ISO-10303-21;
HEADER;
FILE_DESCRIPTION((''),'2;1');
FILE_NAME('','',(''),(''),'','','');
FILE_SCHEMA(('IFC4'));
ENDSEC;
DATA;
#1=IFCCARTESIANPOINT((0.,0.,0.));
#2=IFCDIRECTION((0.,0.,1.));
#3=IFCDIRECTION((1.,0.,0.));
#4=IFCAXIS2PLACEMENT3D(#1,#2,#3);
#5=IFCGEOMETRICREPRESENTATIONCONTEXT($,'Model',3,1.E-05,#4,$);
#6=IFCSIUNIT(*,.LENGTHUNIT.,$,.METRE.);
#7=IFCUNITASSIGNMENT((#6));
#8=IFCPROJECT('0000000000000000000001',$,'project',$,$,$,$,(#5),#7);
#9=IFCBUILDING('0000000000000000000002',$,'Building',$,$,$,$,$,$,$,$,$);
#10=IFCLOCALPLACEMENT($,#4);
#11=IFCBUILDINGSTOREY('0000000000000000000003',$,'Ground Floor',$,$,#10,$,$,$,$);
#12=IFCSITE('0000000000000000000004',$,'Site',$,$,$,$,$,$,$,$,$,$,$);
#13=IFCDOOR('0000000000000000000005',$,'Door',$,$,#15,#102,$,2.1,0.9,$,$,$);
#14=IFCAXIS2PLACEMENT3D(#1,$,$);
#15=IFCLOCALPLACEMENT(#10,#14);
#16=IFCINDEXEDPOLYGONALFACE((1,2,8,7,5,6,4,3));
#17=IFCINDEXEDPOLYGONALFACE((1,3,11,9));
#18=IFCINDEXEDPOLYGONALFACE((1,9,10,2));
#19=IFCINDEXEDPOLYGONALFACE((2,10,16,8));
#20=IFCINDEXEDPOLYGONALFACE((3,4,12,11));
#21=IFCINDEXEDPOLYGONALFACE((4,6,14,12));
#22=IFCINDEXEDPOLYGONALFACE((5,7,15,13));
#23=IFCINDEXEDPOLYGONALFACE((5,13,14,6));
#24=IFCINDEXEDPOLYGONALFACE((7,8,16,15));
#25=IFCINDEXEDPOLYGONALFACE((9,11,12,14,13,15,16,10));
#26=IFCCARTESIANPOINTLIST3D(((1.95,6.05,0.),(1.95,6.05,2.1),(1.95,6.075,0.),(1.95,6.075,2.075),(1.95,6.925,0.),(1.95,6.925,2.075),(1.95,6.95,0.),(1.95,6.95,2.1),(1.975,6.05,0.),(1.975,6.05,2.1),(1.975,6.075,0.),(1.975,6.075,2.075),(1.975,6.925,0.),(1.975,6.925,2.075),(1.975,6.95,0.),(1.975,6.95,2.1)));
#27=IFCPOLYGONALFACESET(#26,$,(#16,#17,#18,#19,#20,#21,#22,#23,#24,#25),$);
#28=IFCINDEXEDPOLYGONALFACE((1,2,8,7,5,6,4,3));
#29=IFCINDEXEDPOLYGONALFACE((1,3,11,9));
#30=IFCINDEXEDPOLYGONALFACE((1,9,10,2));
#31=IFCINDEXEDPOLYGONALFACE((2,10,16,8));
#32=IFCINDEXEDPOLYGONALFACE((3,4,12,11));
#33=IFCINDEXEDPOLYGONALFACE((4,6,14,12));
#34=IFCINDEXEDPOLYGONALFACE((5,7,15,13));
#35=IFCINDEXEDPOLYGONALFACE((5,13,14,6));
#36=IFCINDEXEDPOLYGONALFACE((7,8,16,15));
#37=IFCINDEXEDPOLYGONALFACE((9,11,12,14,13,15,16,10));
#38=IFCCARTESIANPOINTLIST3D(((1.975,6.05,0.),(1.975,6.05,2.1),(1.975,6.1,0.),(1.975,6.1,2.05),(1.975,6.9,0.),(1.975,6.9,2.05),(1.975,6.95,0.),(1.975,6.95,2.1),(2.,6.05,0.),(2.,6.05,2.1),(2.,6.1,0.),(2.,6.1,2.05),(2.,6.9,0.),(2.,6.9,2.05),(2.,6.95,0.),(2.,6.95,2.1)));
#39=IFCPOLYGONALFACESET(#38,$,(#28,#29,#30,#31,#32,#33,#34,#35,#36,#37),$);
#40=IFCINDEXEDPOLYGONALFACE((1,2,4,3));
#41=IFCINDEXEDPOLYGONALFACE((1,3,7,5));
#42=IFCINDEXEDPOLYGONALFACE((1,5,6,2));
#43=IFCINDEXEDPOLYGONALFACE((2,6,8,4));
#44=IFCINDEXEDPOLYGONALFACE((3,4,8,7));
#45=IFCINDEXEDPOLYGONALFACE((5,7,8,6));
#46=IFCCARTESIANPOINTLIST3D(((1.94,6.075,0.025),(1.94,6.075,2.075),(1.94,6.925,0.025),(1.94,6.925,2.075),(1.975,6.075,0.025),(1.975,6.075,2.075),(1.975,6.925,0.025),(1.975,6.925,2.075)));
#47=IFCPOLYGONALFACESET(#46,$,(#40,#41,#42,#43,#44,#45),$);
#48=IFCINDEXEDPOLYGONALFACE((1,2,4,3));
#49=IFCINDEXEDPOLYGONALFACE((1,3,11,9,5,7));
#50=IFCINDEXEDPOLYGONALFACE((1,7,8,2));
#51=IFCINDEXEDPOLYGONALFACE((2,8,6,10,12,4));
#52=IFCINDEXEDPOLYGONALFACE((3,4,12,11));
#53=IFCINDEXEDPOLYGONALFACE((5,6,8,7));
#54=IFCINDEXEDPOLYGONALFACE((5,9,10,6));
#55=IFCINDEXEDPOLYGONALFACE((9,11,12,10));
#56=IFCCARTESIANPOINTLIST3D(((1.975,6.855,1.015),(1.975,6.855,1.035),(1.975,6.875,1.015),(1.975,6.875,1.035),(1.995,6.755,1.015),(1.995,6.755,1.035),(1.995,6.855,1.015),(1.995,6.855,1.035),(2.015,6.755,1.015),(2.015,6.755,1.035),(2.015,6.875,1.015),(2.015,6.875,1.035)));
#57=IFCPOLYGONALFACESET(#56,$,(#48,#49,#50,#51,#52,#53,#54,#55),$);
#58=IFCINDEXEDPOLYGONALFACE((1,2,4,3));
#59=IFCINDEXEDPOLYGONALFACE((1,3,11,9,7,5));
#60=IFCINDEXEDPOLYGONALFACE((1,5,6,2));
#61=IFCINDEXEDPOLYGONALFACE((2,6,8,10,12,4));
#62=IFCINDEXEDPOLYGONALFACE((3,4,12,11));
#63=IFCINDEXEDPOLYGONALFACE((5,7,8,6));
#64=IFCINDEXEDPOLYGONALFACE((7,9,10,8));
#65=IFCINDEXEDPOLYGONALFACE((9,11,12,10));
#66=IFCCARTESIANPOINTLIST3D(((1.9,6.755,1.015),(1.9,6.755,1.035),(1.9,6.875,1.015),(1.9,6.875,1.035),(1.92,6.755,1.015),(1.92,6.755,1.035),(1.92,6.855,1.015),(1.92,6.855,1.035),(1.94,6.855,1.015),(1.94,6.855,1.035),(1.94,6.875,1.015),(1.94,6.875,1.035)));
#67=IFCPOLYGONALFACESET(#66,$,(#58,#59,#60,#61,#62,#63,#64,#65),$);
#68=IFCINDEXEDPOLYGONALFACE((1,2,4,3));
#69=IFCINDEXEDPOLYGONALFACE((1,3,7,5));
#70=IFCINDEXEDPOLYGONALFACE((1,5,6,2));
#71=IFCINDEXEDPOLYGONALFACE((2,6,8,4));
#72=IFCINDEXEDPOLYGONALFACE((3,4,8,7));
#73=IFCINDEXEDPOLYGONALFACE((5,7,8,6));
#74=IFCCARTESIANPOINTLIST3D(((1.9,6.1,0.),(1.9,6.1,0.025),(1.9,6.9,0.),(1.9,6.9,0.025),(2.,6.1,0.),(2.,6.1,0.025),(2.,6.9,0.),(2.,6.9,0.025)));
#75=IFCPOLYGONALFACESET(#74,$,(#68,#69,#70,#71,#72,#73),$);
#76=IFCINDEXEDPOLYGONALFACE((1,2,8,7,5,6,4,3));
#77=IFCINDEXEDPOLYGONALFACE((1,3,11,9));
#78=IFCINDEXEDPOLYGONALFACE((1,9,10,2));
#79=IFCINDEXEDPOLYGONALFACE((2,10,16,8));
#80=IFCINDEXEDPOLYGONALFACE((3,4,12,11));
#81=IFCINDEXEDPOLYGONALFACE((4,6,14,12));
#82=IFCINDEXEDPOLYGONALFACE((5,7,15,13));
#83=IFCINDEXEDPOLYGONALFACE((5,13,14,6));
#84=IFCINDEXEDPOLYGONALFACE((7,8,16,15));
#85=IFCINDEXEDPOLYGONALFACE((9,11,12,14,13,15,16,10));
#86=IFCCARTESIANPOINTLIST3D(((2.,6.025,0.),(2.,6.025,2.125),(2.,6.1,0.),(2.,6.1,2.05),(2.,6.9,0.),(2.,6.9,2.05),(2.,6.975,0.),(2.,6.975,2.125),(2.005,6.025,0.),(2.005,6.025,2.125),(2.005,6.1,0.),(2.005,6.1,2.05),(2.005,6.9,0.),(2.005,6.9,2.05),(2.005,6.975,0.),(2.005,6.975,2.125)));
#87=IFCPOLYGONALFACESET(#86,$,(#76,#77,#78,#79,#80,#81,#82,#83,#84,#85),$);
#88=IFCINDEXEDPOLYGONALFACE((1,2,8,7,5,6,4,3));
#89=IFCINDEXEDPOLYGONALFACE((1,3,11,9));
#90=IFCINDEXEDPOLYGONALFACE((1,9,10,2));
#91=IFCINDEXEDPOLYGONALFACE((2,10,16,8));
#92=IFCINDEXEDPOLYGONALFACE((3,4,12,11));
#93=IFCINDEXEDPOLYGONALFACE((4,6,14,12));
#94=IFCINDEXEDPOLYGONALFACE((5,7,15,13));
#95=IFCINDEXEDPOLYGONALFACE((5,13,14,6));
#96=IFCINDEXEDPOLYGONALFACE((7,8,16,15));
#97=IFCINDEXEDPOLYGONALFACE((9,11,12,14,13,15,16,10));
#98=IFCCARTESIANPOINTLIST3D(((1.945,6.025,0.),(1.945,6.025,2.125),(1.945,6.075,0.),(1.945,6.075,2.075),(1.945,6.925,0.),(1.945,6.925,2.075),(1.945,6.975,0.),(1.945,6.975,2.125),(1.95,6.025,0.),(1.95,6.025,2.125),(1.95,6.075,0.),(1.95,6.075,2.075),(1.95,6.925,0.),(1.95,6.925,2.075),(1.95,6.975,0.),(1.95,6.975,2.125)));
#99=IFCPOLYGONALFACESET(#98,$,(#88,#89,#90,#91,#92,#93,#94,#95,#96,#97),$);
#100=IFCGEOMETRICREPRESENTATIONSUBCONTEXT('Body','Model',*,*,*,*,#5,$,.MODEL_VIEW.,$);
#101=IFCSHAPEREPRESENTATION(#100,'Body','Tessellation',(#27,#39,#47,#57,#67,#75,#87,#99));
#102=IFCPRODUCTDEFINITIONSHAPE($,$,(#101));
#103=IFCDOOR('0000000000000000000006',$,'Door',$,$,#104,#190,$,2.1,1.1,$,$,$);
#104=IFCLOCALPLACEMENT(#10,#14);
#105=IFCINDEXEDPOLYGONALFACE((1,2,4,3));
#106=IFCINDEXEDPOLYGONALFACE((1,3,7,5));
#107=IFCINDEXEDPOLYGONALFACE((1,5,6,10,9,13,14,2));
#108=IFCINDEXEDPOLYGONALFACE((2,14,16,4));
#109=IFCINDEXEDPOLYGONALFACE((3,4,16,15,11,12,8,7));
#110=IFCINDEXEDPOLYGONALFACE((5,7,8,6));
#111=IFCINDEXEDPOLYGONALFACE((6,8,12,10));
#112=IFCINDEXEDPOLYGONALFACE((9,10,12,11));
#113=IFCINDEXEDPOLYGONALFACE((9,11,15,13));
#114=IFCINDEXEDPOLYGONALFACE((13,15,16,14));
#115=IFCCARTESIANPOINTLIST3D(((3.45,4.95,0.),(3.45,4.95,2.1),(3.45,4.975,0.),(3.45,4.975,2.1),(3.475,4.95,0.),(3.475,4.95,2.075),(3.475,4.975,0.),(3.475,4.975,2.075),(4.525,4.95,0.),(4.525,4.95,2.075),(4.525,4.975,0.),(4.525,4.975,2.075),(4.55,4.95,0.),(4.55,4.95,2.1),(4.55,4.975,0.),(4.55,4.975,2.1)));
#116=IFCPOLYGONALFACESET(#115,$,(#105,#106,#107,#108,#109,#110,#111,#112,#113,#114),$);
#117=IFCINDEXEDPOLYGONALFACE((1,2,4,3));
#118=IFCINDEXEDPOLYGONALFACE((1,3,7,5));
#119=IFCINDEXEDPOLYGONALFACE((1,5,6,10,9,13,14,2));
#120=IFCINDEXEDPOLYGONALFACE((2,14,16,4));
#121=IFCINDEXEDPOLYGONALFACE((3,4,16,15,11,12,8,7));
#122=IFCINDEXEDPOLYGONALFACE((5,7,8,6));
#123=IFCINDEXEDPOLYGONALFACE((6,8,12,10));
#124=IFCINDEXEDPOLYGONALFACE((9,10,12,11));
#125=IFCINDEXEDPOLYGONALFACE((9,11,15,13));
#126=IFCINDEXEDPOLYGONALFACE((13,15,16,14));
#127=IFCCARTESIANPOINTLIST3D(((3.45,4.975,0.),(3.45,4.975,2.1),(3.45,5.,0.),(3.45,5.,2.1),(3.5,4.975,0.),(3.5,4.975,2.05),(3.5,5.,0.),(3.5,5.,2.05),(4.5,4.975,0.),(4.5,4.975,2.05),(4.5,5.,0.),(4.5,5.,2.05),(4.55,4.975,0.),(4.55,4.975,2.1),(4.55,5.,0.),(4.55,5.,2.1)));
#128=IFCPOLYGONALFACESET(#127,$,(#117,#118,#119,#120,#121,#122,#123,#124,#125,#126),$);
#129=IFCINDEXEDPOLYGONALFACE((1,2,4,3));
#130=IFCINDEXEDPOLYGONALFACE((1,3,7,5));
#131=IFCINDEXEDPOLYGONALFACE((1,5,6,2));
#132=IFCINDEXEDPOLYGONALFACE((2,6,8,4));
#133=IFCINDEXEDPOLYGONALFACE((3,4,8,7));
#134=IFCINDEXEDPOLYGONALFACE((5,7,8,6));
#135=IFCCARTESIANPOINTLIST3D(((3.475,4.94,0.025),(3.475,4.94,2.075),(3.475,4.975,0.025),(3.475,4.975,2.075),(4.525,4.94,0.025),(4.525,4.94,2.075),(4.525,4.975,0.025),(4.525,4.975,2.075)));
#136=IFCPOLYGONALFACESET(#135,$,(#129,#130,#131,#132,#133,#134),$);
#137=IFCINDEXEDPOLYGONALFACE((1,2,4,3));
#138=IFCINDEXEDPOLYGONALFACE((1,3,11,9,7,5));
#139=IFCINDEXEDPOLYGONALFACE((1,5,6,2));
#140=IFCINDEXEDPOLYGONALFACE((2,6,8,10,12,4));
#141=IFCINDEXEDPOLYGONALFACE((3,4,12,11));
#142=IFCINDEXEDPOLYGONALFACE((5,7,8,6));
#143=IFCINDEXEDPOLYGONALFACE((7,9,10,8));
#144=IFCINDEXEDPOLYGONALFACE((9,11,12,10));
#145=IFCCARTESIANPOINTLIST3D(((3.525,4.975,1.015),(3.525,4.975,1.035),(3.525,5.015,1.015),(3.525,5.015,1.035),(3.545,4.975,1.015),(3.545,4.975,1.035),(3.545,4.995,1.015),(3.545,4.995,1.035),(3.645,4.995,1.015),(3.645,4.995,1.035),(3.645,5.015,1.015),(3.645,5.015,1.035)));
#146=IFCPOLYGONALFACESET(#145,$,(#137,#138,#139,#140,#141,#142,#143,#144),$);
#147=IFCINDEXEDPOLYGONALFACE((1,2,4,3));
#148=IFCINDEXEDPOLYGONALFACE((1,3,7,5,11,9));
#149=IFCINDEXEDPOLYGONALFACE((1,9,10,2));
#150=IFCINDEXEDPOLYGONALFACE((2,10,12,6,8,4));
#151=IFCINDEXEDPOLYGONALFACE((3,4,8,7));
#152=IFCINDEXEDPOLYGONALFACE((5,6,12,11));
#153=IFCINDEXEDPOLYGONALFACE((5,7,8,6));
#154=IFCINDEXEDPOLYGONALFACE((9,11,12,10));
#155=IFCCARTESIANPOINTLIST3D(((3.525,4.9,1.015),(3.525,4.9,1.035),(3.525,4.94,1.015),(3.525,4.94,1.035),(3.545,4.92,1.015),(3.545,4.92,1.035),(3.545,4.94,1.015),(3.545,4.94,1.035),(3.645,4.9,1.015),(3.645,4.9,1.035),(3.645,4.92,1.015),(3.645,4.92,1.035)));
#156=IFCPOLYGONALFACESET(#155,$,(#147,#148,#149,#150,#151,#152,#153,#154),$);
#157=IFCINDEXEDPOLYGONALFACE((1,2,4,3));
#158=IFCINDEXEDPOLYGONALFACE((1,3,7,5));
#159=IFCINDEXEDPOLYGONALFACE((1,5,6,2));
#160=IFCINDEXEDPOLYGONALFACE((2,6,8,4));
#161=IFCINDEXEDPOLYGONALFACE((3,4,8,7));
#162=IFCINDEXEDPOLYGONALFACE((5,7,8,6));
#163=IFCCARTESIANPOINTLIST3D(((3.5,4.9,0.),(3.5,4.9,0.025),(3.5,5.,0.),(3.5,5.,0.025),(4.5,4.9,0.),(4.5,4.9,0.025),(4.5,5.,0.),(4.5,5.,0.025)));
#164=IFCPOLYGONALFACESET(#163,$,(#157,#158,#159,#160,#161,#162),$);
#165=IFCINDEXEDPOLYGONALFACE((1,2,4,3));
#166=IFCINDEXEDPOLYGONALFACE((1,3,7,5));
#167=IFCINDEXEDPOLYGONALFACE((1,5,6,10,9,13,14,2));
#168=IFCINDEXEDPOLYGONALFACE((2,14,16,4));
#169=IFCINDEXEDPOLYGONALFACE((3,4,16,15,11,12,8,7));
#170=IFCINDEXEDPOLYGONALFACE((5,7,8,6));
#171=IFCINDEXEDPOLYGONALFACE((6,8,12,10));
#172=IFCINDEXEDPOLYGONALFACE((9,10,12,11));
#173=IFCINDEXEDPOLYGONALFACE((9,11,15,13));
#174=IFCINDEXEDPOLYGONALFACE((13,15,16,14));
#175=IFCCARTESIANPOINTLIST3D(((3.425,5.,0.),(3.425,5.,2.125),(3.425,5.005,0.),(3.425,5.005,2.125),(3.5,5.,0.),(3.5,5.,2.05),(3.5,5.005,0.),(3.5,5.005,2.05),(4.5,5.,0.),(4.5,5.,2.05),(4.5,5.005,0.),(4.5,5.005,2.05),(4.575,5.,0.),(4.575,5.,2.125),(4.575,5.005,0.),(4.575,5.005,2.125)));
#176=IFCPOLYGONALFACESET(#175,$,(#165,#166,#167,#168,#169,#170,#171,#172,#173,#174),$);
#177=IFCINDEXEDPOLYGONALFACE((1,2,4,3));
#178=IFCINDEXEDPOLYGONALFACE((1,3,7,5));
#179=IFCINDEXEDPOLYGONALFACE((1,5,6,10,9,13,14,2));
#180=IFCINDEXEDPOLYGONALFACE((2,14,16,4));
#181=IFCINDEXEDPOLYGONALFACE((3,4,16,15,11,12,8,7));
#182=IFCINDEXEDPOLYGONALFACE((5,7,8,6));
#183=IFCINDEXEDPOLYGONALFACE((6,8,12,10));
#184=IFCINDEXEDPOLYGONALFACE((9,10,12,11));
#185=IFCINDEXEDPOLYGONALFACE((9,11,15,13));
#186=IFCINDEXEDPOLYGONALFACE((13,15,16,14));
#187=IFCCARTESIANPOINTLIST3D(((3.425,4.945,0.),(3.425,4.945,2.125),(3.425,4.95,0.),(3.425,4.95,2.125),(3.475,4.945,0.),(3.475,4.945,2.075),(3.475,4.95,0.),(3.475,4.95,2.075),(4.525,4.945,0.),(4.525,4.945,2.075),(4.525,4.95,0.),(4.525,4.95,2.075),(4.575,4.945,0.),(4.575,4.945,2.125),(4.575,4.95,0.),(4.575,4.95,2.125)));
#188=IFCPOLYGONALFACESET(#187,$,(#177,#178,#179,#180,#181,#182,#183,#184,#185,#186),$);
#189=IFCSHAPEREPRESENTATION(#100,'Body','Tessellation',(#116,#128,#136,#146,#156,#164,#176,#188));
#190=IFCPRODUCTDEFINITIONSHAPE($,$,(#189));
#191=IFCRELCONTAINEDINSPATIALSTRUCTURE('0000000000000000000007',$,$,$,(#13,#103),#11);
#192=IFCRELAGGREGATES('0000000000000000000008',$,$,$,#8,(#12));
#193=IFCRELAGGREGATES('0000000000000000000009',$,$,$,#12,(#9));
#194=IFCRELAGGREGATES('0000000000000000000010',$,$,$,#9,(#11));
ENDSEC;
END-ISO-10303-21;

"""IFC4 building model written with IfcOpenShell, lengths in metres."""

from ifc_helpers import new_model, si_unit, frame, origin_with_axes, place, context, subcontext, project, spatial, line, indexed_curve, outline, extrude, element, save


model = new_model("IFC4")

# Units and contexts
model_context = context("Model", 3, precision=1e-05, world=origin_with_axes())
body_context = subcontext(model_context, "Body", "Model", "MODEL_VIEW")
ifc_project = project(units=[si_unit("LENGTHUNIT", "METRE")], contexts=[model_context])

# Site, building, storey
site = spatial("IfcSite", under=ifc_project, Name="Site")
building = spatial("IfcBuilding", under=site, Name="Building")
storey_placement = place(None, origin_with_axes())
storey = spatial("IfcBuildingStorey", under=building, at=storey_placement, Name="Ground Floor")

# Doors
door_1_placement = place(storey_placement, frame((2.0, 6.05, 0.0), z_axis=(0.0, 0.0, 1.0), x_axis=(0.0, 1.0, 0.0)))
element("IfcDoor", 1, at=door_1_placement, inside=storey, Name="Door", OverallHeight=2.1, OverallWidth=0.9, context=body_context, shape_type="SweptSolid", body=[
    extrude(outline(indexed_curve([(0.0, 0.0), (0.0, 2.1), (0.9, 2.1), (0.9, 0.0), (0.875, 0.0), (0.875, 2.075), (0.025, 2.075), (0.025, 0.0)], segments=[line(1, 2, 3, 4, 5, 6, 7, 8, 1)])), frame((0.0, 0.025, 0.0), z_axis=(0.0, -1.0, 0.0), x_axis=(1.0, 0.0, 0.0)), (0.0, 0.0, -1.0), 0.025),
    extrude(outline(indexed_curve([(0.0, 0.0), (0.0, 2.1), (0.9, 2.1), (0.9, 0.0), (0.85, 0.0), (0.85, 2.05), (0.05, 2.05), (0.05, 0.0)], segments=[line(1, 2, 3, 4, 5, 6, 7, 8, 1)])), frame((0.0, 0.0, 0.0), z_axis=(0.0, -1.0, 0.0), x_axis=(1.0, 0.0, 0.0)), (0.0, 0.0, -1.0), 0.025),
    extrude(outline(indexed_curve([(0.0, 0.0), (0.85, 0.0), (0.85, 0.035), (0.0, 0.035)], segments=[line(1, 2, 3, 4, 1)])), frame((0.025, 0.025, 0.025), z_axis=(0.0, 0.0, 1.0), x_axis=(1.0, 0.0, 0.0)), (0.0, 0.0, 1.0), 2.05),
    extrude(outline(indexed_curve([(0.0, 0.0), (0.0, -0.04), (-0.12, -0.04), (-0.12, -0.02), (-0.02, -0.02), (-0.02, 0.0)], segments=[line(1, 2, 3, 4, 5, 6, 1)])), frame((0.825, 0.025, 1.015), z_axis=(0.0, 0.0, 1.0), x_axis=(1.0, 0.0, 0.0)), (0.0, 0.0, 1.0), 0.02),
    extrude(outline(indexed_curve([(0.0, 0.0), (0.0, 0.04), (-0.12, 0.04), (-0.12, 0.02), (-0.02, 0.02), (-0.02, 0.0)], segments=[line(1, 2, 3, 4, 5, 6, 1)])), frame((0.825, 0.06, 1.015), z_axis=(0.0, 0.0, 1.0), x_axis=(1.0, 0.0, 0.0)), (0.0, 0.0, 1.0), 0.02),
    extrude(outline(indexed_curve([(0.0, 0.0), (0.8, 0.0), (0.8, 0.1), (0.0, 0.1)], segments=[line(1, 2, 3, 4, 1)])), frame((0.05, 0.0, 0.0), z_axis=(0.0, 0.0, 1.0), x_axis=(1.0, 0.0, 0.0)), (0.0, 0.0, 1.0), 0.025),
    extrude(outline(indexed_curve([(0.0, 0.0), (0.0, 2.125), (0.95, 2.125), (0.95, 0.0), (0.875, 0.0), (0.875, 2.05), (0.075, 2.05), (0.075, 0.0)], segments=[line(1, 2, 3, 4, 5, 6, 7, 8, 1)])), frame((-0.025, -0.005, 0.0), z_axis=(0.0, -1.0, 0.0), x_axis=(1.0, 0.0, 0.0)), (0.0, 0.0, -1.0), 0.005),
    extrude(outline(indexed_curve([(0.0, 0.0), (0.0, 2.125), (0.95, 2.125), (0.95, 0.0), (0.9, 0.0), (0.9, 2.075), (0.05, 2.075), (0.05, 0.0)], segments=[line(1, 2, 3, 4, 5, 6, 7, 8, 1)])), frame((-0.025, 0.05, 0.0), z_axis=(0.0, -1.0, 0.0), x_axis=(1.0, 0.0, 0.0)), (0.0, 0.0, -1.0), 0.005),
])
door_2_placement = place(storey_placement, frame((4.55, 5.0, 0.0), z_axis=(0.0, 0.0, 1.0), x_axis=(-1.0, 0.0, 0.0)))
element("IfcDoor", 2, at=door_2_placement, inside=storey, Name="Door", OverallHeight=2.1, OverallWidth=1.1, context=body_context, shape_type="SweptSolid", body=[
    extrude(outline(indexed_curve([(0.0, 0.0), (0.0, 2.1), (1.1, 2.1), (1.1, 0.0), (1.075, 0.0), (1.075, 2.075), (0.025, 2.075), (0.025, 0.0)], segments=[line(1, 2, 3, 4, 5, 6, 7, 8, 1)])), frame((0.0, 0.025, 0.0), z_axis=(0.0, -1.0, 0.0), x_axis=(1.0, 0.0, 0.0)), (0.0, 0.0, -1.0), 0.025),
    extrude(outline(indexed_curve([(0.0, 0.0), (0.0, 2.1), (1.1, 2.1), (1.1, 0.0), (1.05, 0.0), (1.05, 2.05), (0.05, 2.05), (0.05, 0.0)], segments=[line(1, 2, 3, 4, 5, 6, 7, 8, 1)])), frame((0.0, 0.0, 0.0), z_axis=(0.0, -1.0, 0.0), x_axis=(1.0, 0.0, 0.0)), (0.0, 0.0, -1.0), 0.025),
    extrude(outline(indexed_curve([(0.0, 0.0), (1.05, 0.0), (1.05, 0.035), (0.0, 0.035)], segments=[line(1, 2, 3, 4, 1)])), frame((0.025, 0.025, 0.025), z_axis=(0.0, 0.0, 1.0), x_axis=(1.0, 0.0, 0.0)), (0.0, 0.0, 1.0), 2.05),
    extrude(outline(indexed_curve([(0.0, 0.0), (0.0, -0.04), (-0.12, -0.04), (-0.12, -0.02), (-0.02, -0.02), (-0.02, 0.0)], segments=[line(1, 2, 3, 4, 5, 6, 1)])), frame((1.025, 0.025, 1.015), z_axis=(0.0, 0.0, 1.0), x_axis=(1.0, 0.0, 0.0)), (0.0, 0.0, 1.0), 0.02),
    extrude(outline(indexed_curve([(0.0, 0.0), (0.0, 0.04), (-0.12, 0.04), (-0.12, 0.02), (-0.02, 0.02), (-0.02, 0.0)], segments=[line(1, 2, 3, 4, 5, 6, 1)])), frame((1.025, 0.06, 1.015), z_axis=(0.0, 0.0, 1.0), x_axis=(1.0, 0.0, 0.0)), (0.0, 0.0, 1.0), 0.02),
    extrude(outline(indexed_curve([(0.0, 0.0), (1.0, 0.0), (1.0, 0.1), (0.0, 0.1)], segments=[line(1, 2, 3, 4, 1)])), frame((0.05, 0.0, 0.0), z_axis=(0.0, 0.0, 1.0), x_axis=(1.0, 0.0, 0.0)), (0.0, 0.0, 1.0), 0.025),
    extrude(outline(indexed_curve([(0.0, 0.0), (0.0, 2.125), (1.15, 2.125), (1.15, 0.0), (1.075, 0.0), (1.075, 2.05), (0.075, 2.05), (0.075, 0.0)], segments=[line(1, 2, 3, 4, 5, 6, 7, 8, 1)])), frame((-0.025, -0.005, 0.0), z_axis=(0.0, -1.0, 0.0), x_axis=(1.0, 0.0, 0.0)), (0.0, 0.0, -1.0), 0.005),
    extrude(outline(indexed_curve([(0.0, 0.0), (0.0, 2.125), (1.15, 2.125), (1.15, 0.0), (1.1, 0.0), (1.1, 2.075), (0.05, 2.075), (0.05, 0.0)], segments=[line(1, 2, 3, 4, 5, 6, 7, 8, 1)])), frame((-0.025, 0.05, 0.0), z_axis=(0.0, -1.0, 0.0), x_axis=(1.0, 0.0, 0.0)), (0.0, 0.0, -1.0), 0.005),
])

save(model, "model.ifc")
